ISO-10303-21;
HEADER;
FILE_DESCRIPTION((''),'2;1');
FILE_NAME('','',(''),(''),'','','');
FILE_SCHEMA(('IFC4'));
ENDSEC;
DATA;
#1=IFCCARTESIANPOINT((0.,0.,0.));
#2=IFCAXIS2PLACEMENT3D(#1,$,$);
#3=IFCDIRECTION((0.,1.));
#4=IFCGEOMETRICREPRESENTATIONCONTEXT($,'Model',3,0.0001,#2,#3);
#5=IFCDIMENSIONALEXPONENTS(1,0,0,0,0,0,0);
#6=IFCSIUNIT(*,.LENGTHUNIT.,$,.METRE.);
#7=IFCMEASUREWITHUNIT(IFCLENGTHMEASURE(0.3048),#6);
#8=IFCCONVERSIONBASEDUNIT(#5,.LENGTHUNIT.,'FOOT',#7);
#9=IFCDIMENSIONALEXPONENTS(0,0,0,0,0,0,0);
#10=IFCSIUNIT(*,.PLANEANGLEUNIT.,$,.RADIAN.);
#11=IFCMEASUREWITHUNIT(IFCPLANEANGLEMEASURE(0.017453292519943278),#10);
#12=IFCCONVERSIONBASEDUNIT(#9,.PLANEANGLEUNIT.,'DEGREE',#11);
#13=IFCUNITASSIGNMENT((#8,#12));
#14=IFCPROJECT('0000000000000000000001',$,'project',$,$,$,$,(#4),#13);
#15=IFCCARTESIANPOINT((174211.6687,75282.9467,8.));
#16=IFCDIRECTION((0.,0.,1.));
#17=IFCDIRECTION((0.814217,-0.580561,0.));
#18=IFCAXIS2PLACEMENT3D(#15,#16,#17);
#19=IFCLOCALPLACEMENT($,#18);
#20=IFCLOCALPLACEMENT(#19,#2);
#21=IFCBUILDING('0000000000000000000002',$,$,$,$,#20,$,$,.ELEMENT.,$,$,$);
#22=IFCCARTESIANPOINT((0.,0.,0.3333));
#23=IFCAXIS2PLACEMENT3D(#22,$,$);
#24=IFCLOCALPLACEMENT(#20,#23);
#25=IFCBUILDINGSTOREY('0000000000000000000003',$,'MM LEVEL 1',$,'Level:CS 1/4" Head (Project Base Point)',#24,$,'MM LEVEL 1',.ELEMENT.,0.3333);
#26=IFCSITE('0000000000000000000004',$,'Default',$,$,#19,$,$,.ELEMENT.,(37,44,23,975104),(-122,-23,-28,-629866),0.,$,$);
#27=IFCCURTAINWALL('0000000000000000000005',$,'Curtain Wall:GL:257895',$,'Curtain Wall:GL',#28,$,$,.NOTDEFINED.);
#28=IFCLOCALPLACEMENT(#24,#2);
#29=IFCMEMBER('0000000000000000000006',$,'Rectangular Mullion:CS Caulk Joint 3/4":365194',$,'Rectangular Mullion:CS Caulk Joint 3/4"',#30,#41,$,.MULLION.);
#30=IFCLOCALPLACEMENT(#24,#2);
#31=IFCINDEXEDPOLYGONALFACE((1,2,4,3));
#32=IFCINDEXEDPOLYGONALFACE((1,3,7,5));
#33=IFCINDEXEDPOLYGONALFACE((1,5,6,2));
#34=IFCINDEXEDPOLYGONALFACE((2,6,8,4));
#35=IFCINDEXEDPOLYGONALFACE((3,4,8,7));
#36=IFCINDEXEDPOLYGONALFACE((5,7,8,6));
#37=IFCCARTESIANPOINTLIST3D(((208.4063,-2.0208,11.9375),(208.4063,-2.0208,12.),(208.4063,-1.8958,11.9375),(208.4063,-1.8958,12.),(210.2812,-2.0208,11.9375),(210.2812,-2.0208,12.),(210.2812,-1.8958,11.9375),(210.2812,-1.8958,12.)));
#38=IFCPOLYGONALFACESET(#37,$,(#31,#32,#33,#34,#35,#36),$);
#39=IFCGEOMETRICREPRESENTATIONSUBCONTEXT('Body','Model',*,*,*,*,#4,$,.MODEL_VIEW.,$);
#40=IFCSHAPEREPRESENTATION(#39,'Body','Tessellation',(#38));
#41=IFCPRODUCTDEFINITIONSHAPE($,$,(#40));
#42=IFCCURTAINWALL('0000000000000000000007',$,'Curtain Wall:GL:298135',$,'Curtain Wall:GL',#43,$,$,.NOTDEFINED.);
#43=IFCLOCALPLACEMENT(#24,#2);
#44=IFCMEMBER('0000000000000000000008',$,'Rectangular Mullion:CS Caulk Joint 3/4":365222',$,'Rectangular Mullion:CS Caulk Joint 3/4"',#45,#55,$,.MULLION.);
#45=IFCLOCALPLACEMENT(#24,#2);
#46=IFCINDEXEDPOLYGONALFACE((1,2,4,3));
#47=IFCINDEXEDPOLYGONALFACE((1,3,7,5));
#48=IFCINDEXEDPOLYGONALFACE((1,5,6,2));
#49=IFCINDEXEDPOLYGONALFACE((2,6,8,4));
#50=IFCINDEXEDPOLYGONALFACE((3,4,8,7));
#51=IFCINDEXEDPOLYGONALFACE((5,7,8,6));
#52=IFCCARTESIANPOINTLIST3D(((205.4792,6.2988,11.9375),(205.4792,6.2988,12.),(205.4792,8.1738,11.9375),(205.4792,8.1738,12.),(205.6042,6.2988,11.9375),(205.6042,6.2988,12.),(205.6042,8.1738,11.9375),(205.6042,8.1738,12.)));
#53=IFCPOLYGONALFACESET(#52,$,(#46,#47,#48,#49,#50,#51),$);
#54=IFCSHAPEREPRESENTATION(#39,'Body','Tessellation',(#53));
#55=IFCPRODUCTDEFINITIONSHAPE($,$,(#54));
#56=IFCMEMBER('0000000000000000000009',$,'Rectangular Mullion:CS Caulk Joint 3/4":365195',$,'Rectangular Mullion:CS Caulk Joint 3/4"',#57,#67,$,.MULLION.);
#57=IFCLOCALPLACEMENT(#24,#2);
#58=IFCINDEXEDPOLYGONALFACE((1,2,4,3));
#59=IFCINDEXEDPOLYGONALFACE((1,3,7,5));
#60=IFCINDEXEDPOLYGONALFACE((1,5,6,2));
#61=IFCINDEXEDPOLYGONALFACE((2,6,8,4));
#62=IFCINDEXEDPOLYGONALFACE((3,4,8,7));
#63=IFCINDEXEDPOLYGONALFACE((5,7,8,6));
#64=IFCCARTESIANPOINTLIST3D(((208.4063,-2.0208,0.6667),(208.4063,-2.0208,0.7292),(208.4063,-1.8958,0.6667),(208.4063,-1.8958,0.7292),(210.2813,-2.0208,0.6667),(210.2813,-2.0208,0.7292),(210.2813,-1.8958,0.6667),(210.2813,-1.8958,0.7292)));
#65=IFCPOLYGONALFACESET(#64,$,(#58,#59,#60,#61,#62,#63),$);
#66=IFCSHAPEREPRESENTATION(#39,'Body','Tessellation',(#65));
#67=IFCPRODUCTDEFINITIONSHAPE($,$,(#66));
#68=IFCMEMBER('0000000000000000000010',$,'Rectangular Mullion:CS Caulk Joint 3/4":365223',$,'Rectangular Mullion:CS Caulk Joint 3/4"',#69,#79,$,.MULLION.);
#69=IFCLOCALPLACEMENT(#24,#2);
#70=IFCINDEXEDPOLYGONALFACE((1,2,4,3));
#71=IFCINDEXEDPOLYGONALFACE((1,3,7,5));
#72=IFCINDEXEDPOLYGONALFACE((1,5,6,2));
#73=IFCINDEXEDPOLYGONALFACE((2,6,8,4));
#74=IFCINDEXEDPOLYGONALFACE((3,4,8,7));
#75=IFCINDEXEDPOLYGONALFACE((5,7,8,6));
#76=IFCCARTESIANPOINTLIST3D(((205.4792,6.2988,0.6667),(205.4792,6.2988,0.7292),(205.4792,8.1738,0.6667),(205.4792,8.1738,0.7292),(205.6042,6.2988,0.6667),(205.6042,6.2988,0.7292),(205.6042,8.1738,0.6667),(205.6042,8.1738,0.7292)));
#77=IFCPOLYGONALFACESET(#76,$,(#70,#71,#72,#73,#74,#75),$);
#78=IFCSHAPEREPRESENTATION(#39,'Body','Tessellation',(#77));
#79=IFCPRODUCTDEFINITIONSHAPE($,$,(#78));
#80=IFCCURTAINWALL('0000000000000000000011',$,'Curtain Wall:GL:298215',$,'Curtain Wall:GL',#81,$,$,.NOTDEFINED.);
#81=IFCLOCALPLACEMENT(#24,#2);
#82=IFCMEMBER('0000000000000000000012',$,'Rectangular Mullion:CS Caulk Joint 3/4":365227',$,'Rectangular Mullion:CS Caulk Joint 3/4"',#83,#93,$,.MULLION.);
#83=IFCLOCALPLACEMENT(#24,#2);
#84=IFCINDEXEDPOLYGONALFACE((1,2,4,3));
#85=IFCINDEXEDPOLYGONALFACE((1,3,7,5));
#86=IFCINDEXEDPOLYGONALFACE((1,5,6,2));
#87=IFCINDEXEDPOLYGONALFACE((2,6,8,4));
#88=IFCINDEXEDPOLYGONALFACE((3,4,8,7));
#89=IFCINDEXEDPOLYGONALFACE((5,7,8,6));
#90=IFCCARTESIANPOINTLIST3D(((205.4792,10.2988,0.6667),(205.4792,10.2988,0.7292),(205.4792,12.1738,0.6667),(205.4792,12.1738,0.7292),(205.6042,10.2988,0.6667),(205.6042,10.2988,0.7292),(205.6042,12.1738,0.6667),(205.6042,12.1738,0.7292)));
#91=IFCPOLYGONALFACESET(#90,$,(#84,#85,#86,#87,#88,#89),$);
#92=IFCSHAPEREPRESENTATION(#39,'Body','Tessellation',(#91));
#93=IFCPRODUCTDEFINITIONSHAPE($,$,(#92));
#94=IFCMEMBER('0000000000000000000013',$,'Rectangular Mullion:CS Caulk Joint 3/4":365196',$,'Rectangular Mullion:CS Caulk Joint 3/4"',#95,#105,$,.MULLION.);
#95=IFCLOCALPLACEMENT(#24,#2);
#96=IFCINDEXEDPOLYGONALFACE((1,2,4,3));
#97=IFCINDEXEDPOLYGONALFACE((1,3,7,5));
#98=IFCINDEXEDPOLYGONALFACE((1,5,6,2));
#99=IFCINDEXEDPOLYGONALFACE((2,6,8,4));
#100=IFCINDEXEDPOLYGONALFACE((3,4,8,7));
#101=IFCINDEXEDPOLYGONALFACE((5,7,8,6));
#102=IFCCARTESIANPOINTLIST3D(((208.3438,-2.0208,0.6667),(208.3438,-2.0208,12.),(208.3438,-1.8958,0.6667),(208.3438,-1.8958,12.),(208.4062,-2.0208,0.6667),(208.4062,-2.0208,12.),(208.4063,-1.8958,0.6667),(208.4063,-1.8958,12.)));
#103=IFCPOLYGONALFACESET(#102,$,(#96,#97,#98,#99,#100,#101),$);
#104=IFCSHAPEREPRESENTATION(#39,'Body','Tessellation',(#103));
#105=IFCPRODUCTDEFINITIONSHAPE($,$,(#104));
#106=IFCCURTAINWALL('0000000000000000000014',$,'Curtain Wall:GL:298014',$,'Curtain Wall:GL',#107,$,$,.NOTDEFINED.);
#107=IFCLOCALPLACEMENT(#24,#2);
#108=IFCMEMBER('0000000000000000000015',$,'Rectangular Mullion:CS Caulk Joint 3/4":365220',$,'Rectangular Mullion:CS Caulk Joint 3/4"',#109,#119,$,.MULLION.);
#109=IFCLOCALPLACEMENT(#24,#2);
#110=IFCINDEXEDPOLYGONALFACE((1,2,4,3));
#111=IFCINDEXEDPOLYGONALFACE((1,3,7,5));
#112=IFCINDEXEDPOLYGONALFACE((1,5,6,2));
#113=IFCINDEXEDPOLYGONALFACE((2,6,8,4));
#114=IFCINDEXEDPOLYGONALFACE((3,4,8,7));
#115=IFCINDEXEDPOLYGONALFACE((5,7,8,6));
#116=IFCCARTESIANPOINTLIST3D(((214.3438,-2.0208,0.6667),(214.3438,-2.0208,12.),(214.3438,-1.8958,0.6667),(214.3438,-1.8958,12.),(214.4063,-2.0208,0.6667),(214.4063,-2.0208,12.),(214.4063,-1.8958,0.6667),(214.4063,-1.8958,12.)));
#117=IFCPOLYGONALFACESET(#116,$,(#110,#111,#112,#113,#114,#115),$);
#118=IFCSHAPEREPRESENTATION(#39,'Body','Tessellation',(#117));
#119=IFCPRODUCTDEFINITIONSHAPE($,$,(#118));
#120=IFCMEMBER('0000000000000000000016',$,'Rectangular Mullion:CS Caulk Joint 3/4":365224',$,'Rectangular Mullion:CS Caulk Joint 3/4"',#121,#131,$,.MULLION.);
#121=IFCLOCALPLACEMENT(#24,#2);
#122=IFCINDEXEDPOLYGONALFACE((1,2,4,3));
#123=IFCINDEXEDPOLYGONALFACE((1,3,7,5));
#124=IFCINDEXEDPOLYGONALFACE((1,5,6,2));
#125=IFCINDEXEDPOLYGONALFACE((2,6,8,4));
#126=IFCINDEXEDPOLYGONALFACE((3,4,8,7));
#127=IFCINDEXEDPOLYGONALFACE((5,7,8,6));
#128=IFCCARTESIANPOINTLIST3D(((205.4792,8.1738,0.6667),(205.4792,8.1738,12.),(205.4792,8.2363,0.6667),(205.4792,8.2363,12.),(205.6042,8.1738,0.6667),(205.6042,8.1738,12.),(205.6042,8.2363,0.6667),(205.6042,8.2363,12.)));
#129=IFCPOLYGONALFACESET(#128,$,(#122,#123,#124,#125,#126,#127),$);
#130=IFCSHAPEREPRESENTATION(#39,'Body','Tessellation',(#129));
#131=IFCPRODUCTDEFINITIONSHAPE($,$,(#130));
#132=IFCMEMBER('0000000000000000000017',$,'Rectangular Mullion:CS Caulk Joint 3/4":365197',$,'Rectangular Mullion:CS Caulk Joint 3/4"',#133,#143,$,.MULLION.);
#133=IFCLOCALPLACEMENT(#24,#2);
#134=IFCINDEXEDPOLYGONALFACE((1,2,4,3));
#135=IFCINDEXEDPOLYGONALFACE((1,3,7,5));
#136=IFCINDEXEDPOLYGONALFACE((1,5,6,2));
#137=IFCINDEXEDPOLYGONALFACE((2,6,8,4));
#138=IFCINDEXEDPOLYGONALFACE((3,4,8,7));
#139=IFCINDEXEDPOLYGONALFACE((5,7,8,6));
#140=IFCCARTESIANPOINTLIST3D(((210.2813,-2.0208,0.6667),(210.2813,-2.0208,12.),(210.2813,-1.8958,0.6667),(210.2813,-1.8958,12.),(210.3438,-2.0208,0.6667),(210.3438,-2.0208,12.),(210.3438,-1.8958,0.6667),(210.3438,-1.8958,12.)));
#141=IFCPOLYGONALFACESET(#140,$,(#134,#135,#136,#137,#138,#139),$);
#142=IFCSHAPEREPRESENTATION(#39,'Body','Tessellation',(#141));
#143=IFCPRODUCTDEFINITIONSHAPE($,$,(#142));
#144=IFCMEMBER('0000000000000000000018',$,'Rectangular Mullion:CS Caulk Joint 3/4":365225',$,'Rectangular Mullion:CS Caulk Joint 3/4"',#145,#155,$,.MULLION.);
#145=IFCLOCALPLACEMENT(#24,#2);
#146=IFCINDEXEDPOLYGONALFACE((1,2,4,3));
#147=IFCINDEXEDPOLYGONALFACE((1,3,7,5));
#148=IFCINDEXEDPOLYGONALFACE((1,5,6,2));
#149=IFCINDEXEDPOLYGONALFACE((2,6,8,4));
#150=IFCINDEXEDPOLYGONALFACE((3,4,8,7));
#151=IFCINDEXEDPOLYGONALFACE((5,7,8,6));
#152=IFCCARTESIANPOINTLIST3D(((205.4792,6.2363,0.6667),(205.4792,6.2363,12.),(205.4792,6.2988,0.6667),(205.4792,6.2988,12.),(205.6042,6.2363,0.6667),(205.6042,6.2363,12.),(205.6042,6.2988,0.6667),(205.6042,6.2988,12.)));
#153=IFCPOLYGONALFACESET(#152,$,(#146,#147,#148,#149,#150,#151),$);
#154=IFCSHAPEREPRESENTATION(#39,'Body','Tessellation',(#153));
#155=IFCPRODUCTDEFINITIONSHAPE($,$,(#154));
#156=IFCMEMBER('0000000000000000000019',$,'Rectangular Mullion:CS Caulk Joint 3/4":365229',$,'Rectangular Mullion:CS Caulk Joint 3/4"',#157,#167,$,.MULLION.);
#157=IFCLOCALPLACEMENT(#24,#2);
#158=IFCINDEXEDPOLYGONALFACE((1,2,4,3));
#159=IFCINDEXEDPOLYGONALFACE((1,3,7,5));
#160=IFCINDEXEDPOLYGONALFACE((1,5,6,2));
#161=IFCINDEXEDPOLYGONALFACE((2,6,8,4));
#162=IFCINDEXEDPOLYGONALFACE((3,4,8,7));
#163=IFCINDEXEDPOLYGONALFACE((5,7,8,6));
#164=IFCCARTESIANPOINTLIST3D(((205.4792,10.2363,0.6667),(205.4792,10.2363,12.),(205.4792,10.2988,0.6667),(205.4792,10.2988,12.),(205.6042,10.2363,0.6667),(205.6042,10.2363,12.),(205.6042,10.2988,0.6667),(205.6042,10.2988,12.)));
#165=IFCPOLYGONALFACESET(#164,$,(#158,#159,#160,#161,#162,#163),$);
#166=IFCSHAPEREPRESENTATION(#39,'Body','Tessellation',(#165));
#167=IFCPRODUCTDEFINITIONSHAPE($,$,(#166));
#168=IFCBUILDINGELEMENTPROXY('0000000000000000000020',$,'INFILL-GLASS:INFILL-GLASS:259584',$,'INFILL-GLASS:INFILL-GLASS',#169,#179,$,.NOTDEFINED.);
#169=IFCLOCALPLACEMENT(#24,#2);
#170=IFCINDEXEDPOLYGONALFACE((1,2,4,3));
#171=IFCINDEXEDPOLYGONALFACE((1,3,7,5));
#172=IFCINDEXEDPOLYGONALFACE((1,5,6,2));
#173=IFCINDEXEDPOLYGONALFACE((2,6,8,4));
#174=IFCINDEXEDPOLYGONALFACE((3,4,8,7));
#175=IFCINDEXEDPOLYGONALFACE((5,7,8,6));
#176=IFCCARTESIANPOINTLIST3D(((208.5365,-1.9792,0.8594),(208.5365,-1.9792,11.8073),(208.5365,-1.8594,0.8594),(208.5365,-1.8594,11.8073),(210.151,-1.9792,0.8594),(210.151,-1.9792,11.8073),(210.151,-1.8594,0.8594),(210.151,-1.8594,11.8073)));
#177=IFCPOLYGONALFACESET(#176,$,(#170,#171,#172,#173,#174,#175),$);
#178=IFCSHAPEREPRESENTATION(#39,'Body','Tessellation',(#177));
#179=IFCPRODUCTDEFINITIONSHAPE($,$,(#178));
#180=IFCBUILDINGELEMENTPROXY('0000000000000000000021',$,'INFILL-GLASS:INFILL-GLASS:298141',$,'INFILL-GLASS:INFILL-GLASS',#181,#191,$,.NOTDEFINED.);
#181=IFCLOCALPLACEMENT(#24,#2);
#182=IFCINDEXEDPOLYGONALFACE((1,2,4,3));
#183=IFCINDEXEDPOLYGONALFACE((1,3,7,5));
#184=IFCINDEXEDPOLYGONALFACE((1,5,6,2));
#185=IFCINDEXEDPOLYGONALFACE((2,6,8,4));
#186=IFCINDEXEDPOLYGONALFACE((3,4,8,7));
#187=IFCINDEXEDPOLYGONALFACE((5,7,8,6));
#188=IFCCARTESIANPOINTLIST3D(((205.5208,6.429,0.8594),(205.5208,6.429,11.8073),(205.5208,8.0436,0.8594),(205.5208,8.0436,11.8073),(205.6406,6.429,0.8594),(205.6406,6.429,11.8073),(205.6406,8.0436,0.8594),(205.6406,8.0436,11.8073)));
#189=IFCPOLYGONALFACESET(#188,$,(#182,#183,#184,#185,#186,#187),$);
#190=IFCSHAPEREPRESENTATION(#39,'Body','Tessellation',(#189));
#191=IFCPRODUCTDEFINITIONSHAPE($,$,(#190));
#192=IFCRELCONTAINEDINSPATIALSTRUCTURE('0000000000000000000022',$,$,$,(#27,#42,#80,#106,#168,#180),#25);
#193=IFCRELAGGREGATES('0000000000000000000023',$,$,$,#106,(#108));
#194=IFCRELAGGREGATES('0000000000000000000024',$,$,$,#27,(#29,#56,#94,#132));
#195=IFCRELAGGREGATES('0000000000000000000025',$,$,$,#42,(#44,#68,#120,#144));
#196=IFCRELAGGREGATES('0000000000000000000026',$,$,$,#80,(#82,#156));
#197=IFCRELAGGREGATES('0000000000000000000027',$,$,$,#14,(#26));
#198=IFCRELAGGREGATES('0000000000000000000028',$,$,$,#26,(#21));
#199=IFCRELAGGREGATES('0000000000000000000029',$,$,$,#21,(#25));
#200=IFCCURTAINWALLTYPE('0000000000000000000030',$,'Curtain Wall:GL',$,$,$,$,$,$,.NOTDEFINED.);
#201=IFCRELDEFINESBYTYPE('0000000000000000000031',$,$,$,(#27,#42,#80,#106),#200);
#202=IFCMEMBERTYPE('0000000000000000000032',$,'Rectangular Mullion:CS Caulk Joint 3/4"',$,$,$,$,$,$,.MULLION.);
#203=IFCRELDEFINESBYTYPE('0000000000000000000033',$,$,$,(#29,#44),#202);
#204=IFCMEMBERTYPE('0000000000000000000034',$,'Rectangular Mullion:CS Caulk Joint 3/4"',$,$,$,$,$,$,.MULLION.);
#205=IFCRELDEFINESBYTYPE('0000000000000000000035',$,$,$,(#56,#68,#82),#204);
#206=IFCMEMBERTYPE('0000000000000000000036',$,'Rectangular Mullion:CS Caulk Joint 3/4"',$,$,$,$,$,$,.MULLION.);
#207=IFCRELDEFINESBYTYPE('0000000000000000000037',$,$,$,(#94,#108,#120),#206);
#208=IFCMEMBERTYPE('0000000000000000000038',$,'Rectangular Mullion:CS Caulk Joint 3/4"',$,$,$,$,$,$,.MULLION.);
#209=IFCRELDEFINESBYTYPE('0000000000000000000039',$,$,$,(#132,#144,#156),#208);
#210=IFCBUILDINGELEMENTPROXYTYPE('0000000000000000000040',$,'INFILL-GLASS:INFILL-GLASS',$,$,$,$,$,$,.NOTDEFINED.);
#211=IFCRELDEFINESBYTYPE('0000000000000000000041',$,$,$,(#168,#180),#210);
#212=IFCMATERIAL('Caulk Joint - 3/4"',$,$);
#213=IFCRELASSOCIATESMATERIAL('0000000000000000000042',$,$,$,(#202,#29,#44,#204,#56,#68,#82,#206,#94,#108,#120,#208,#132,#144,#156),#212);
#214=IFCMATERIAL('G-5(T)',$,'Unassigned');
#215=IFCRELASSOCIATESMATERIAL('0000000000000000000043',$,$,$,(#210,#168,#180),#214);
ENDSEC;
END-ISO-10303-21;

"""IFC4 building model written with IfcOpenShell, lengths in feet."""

from ifc_helpers import new_model, entity, si_unit, converted_unit, direction, frame, origin, place, context, subcontext, project, spatial, indexed_curve, outline, extrude, source, transform, mapped, material, type_object, type_shapes, element, aggregate, save


model = new_model("IFC4")

# Units and contexts
model_context = context("Model", 3, precision=0.0001, world=origin(), true_north=direction((0.0, 1.0)))
body_context = subcontext(model_context, "Body", "Model", "MODEL_VIEW")
ifc_project = project(units=[converted_unit("LENGTHUNIT", "FOOT", entity("IfcLengthMeasure", 0.3048), si_unit("LENGTHUNIT", "METRE"), dimensions=[1, 0, 0, 0, 0, 0, 0]), converted_unit("PLANEANGLEUNIT", "DEGREE", entity("IfcPlaneAngleMeasure", 0.017453292519943278), si_unit("PLANEANGLEUNIT", "RADIAN"), dimensions=[0, 0, 0, 0, 0, 0, 0])], contexts=[model_context])

# Site, building, storey
site_placement = place(None, frame((174211.6687, 75282.9467, 8.0), z_axis=(0.0, 0.0, 1.0), x_axis=(0.814217, -0.580561, 0.0)))
site = spatial("IfcSite", under=ifc_project, at=site_placement, Name="Default", CompositionType="ELEMENT", RefLatitude=(37, 44, 23, 975104), RefLongitude=(-122, -23, -28, -629866), RefElevation=0.0)
building_placement = place(site_placement, origin())
building = spatial("IfcBuilding", under=site, at=building_placement, CompositionType="ELEMENT")
storey_placement = place(building_placement, frame((0.0, 0.0, 0.3333)))
storey = spatial("IfcBuildingStorey", under=building, at=storey_placement, Name="MM LEVEL 1", ObjectType="Level:CS 1/4\" Head (Project Base Point)", LongName="MM LEVEL 1", CompositionType="ELEMENT", Elevation=0.3333)

# Curtain walls, members
curtain_wall_type = type_object("IfcCurtainWallType", Name="Curtain Wall:GL", PredefinedType="NOTDEFINED")
curtain_wall_1_placement = place(storey_placement, frame((0.0, 0.0, -0.3333)))
curtain_wall_1 = element("IfcCurtainWall", 1, at=curtain_wall_1_placement, inside=storey, type_object=curtain_wall_type, Name="Curtain Wall:GL:257895", ObjectType="Curtain Wall:GL", PredefinedType="NOTDEFINED")
ifc_material_1 = material(Name="Caulk Joint - 3/4\"")
member_type_1 = type_object("IfcMemberType", Name="Rectangular Mullion:CS Caulk Joint 3/4\"", PredefinedType="MULLION", material=ifc_material_1)
shared_shape_1 = source(origin(), body_context, "Body", "SweptSolid", [
    extrude(outline(indexed_curve([(-0.0625, -0.0312), (0.0625, -0.0312), (0.0625, 0.0312), (-0.0625, 0.0312), (-0.0625, -0.0312)], self_intersect=False)), frame((-0.0312, 0.0625, -1.875), z_axis=(0.0, 0.0, 1.0), x_axis=(0.0, -1.0, 0.0)), (0.0, 0.0, 1.0), 1.875),
])
type_shapes(member_type_1, [shared_shape_1])
member_1_placement = place(curtain_wall_1_placement, frame((208.4062, -2.0208, 12.3333), z_axis=(-1.0, 0.0, 0.0), x_axis=(0.0, 0.0, 1.0)))
member_1 = element("IfcMember", 2, at=member_1_placement, type_object=member_type_1, material=ifc_material_1, Name="Rectangular Mullion:CS Caulk Joint 3/4\":365194", ObjectType="Rectangular Mullion:CS Caulk Joint 3/4\"", PredefinedType="MULLION", context=body_context, shape_type="MappedRepresentation", body=[
    mapped(shared_shape_1, transform((0.0, 0.0, 0.0), scale=1.0)),
])
curtain_wall_2_placement = place(storey_placement, frame((0.0, 0.0, -0.3333)))
curtain_wall_2 = element("IfcCurtainWall", 3, at=curtain_wall_2_placement, inside=storey, type_object=curtain_wall_type, Name="Curtain Wall:GL:298135", ObjectType="Curtain Wall:GL", PredefinedType="NOTDEFINED")
member_2_placement = place(curtain_wall_2_placement, frame((205.4792, 8.1738, 12.3333), z_axis=(0.0, 1.0, 0.0), x_axis=(0.0, 0.0, 1.0)))
member_2 = element("IfcMember", 4, at=member_2_placement, type_object=member_type_1, material=ifc_material_1, Name="Rectangular Mullion:CS Caulk Joint 3/4\":365222", ObjectType="Rectangular Mullion:CS Caulk Joint 3/4\"", PredefinedType="MULLION", context=body_context, shape_type="MappedRepresentation", body=[
    mapped(shared_shape_1, transform((0.0, 0.0, 0.0), scale=1.0)),
])

# Members
member_type_2 = type_object("IfcMemberType", Name="Rectangular Mullion:CS Caulk Joint 3/4\"", PredefinedType="MULLION", material=ifc_material_1)
shared_shape_2 = source(origin(), body_context, "Body", "SweptSolid", [
    extrude(outline(indexed_curve([(-0.0312, -0.0625), (0.0312, -0.0625), (0.0312, 0.0625), (-0.0312, 0.0625), (-0.0312, -0.0625)], self_intersect=False)), frame((-0.0312, 0.0625, -1.875), z_axis=(0.0, 0.0, 1.0), x_axis=(-1.0, 0.0, 0.0)), (0.0, 0.0, 1.0), 1.875),
])
type_shapes(member_type_2, [shared_shape_2])
member_3_placement = place(curtain_wall_1_placement, frame((210.2813, -2.0208, 1.0), z_axis=(1.0, 0.0, 0.0), x_axis=(0.0, 0.0, -1.0)))
member_3 = element("IfcMember", 5, at=member_3_placement, type_object=member_type_2, material=ifc_material_1, Name="Rectangular Mullion:CS Caulk Joint 3/4\":365195", ObjectType="Rectangular Mullion:CS Caulk Joint 3/4\"", PredefinedType="MULLION", context=body_context, shape_type="MappedRepresentation", body=[
    mapped(shared_shape_2, transform((0.0, 0.0, 0.0), scale=1.0)),
])
member_4_placement = place(curtain_wall_2_placement, frame((205.4792, 6.2988, 1.0), z_axis=(0.0, -1.0, 0.0), x_axis=(0.0, 0.0, -1.0)))
member_4 = element("IfcMember", 6, at=member_4_placement, type_object=member_type_2, material=ifc_material_1, Name="Rectangular Mullion:CS Caulk Joint 3/4\":365223", ObjectType="Rectangular Mullion:CS Caulk Joint 3/4\"", PredefinedType="MULLION", context=body_context, shape_type="MappedRepresentation", body=[
    mapped(shared_shape_2, transform((0.0, 0.0, 0.0), scale=1.0)),
])

# Curtain wall, member
curtain_wall_3_placement = place(storey_placement, frame((0.0, 0.0, -0.3333)))
curtain_wall_3 = element("IfcCurtainWall", 7, at=curtain_wall_3_placement, inside=storey, type_object=curtain_wall_type, Name="Curtain Wall:GL:298215", ObjectType="Curtain Wall:GL", PredefinedType="NOTDEFINED")
member_5_placement = place(curtain_wall_3_placement, frame((205.4792, 10.2988, 1.0), z_axis=(0.0, -1.0, 0.0), x_axis=(0.0, 0.0, -1.0)))
member_5 = element("IfcMember", 8, at=member_5_placement, type_object=member_type_2, material=ifc_material_1, Name="Rectangular Mullion:CS Caulk Joint 3/4\":365227", ObjectType="Rectangular Mullion:CS Caulk Joint 3/4\"", PredefinedType="MULLION", context=body_context, shape_type="MappedRepresentation", body=[
    mapped(shared_shape_2, transform((0.0, 0.0, 0.0), scale=1.0)),
])

# Member
member_type_3 = type_object("IfcMemberType", Name="Rectangular Mullion:CS Caulk Joint 3/4\"", PredefinedType="MULLION", material=ifc_material_1)
shared_shape_3 = source(origin(), body_context, "Body", "SweptSolid", [
    extrude(outline(indexed_curve([(-0.0625, -0.0312), (0.0625, -0.0312), (0.0625, 0.0312), (-0.0625, 0.0312), (-0.0625, -0.0312)], self_intersect=False)), frame((-0.0312, 0.0625, -11.3333), z_axis=(0.0, 0.0, 1.0), x_axis=(0.0, -1.0, 0.0)), (0.0, 0.0, 1.0), 11.3333),
])
type_shapes(member_type_3, [shared_shape_3])
member_6_placement = place(curtain_wall_1_placement, frame((208.3438, -2.0208, 1.0), z_axis=(0.0, 0.0, -1.0), x_axis=(-1.0, 0.0, 0.0)))
member_6 = element("IfcMember", 9, at=member_6_placement, type_object=member_type_3, material=ifc_material_1, Name="Rectangular Mullion:CS Caulk Joint 3/4\":365196", ObjectType="Rectangular Mullion:CS Caulk Joint 3/4\"", PredefinedType="MULLION", context=body_context, shape_type="MappedRepresentation", body=[
    mapped(shared_shape_3, transform((0.0, 0.0, 0.0), scale=1.0)),
])

# Curtain wall, member
curtain_wall_4_placement = place(storey_placement, frame((0.0, 0.0, -0.3333)))
curtain_wall_4 = element("IfcCurtainWall", 10, at=curtain_wall_4_placement, inside=storey, type_object=curtain_wall_type, Name="Curtain Wall:GL:298014", ObjectType="Curtain Wall:GL", PredefinedType="NOTDEFINED")
member_7_placement = place(curtain_wall_4_placement, frame((214.3437, -2.0208, 1.0), z_axis=(0.0, 0.0, -1.0), x_axis=(-1.0, 0.0, 0.0)))
member_7 = element("IfcMember", 11, at=member_7_placement, type_object=member_type_3, material=ifc_material_1, Name="Rectangular Mullion:CS Caulk Joint 3/4\":365220", ObjectType="Rectangular Mullion:CS Caulk Joint 3/4\"", PredefinedType="MULLION", context=body_context, shape_type="MappedRepresentation", body=[
    mapped(shared_shape_3, transform((0.0, 0.0, 0.0), scale=1.0)),
])
aggregate(curtain_wall_4, [member_7])

# Members
member_8_placement = place(curtain_wall_2_placement, frame((205.4792, 8.2363, 1.0), z_axis=(0.0, 0.0, -1.0), x_axis=(0.0, 1.0, 0.0)))
member_8 = element("IfcMember", 12, at=member_8_placement, type_object=member_type_3, material=ifc_material_1, Name="Rectangular Mullion:CS Caulk Joint 3/4\":365224", ObjectType="Rectangular Mullion:CS Caulk Joint 3/4\"", PredefinedType="MULLION", context=body_context, shape_type="MappedRepresentation", body=[
    mapped(shared_shape_3, transform((0.0, 0.0, 0.0), scale=1.0)),
])
member_type_4 = type_object("IfcMemberType", Name="Rectangular Mullion:CS Caulk Joint 3/4\"", PredefinedType="MULLION", material=ifc_material_1)
shared_shape_4 = source(origin(), body_context, "Body", "SweptSolid", [
    extrude(outline(indexed_curve([(-0.0312, -0.0625), (0.0312, -0.0625), (0.0312, 0.0625), (-0.0312, 0.0625), (-0.0312, -0.0625)], self_intersect=False)), frame((-0.0312, 0.0625, -11.3333), z_axis=(0.0, 0.0, 1.0), x_axis=(-1.0, 0.0, 0.0)), (0.0, 0.0, 1.0), 11.3333),
])
type_shapes(member_type_4, [shared_shape_4])
member_9_placement = place(curtain_wall_1_placement, frame((210.3438, -2.0208, 12.3333)))
member_9 = element("IfcMember", 13, at=member_9_placement, type_object=member_type_4, material=ifc_material_1, Name="Rectangular Mullion:CS Caulk Joint 3/4\":365197", ObjectType="Rectangular Mullion:CS Caulk Joint 3/4\"", PredefinedType="MULLION", context=body_context, shape_type="MappedRepresentation", body=[
    mapped(shared_shape_4, transform((0.0, 0.0, 0.0), scale=1.0)),
])
aggregate(curtain_wall_1, [member_1, member_3, member_6, member_9])
member_10_placement = place(curtain_wall_2_placement, frame((205.4792, 6.2363, 12.3333), z_axis=(0.0, 0.0, 1.0), x_axis=(0.0, -1.0, 0.0)))
member_10 = element("IfcMember", 14, at=member_10_placement, type_object=member_type_4, material=ifc_material_1, Name="Rectangular Mullion:CS Caulk Joint 3/4\":365225", ObjectType="Rectangular Mullion:CS Caulk Joint 3/4\"", PredefinedType="MULLION", context=body_context, shape_type="MappedRepresentation", body=[
    mapped(shared_shape_4, transform((0.0, 0.0, 0.0), scale=1.0)),
])
aggregate(curtain_wall_2, [member_2, member_4, member_8, member_10])
member_11_placement = place(curtain_wall_3_placement, frame((205.4792, 10.2363, 12.3333), z_axis=(0.0, 0.0, 1.0), x_axis=(0.0, -1.0, 0.0)))
member_11 = element("IfcMember", 15, at=member_11_placement, type_object=member_type_4, material=ifc_material_1, Name="Rectangular Mullion:CS Caulk Joint 3/4\":365229", ObjectType="Rectangular Mullion:CS Caulk Joint 3/4\"", PredefinedType="MULLION", context=body_context, shape_type="MappedRepresentation", body=[
    mapped(shared_shape_4, transform((0.0, 0.0, 0.0), scale=1.0)),
])
aggregate(curtain_wall_3, [member_5, member_11])

# Building element proxies
ifc_material_2 = material(Name="G-5(T)", Category="Unassigned")
building_element_proxy_type_1 = type_object("IfcBuildingElementProxyType", Name="INFILL-GLASS:INFILL-GLASS", PredefinedType="NOTDEFINED", material=ifc_material_2)
shared_shape_5 = source(origin(), body_context, "Body", "SweptSolid", [
    extrude(outline(indexed_curve([(-0.0599, -0.8073), (0.0599, -0.8073), (0.0599, 0.8073), (-0.0599, 0.8073), (-0.0599, -0.8073)], self_intersect=False)), frame((0.0, 0.1016, 0.1302), z_axis=(0.0, 0.0, 1.0), x_axis=(0.0, 1.0, 0.0)), (0.0, 0.0, 1.0), 10.9479),
])
type_shapes(building_element_proxy_type_1, [shared_shape_5])
proxy_1_placement = place(storey_placement, frame((209.3438, -2.0208, 0.7292)))
element("IfcBuildingElementProxy", 16, at=proxy_1_placement, inside=storey, type_object=building_element_proxy_type_1, material=ifc_material_2, Name="INFILL-GLASS:INFILL-GLASS:259584", ObjectType="INFILL-GLASS:INFILL-GLASS", PredefinedType="NOTDEFINED", context=body_context, shape_type="MappedRepresentation", body=[
    mapped(shared_shape_5, transform((0.0, 0.0, 0.0), scale=1.0)),
])
proxy_2_placement = place(storey_placement, frame((205.4792, 7.2363, 0.7292), z_axis=(0.0, 0.0, 1.0), x_axis=(0.0, -1.0, 0.0)))
element("IfcBuildingElementProxy", 17, at=proxy_2_placement, inside=storey, type_object=building_element_proxy_type_1, material=ifc_material_2, Name="INFILL-GLASS:INFILL-GLASS:298141", ObjectType="INFILL-GLASS:INFILL-GLASS", PredefinedType="NOTDEFINED", context=body_context, shape_type="MappedRepresentation", body=[
    mapped(shared_shape_5, transform((0.0, 0.0, 0.0), scale=1.0)),
])

save(model, "model.ifc")
